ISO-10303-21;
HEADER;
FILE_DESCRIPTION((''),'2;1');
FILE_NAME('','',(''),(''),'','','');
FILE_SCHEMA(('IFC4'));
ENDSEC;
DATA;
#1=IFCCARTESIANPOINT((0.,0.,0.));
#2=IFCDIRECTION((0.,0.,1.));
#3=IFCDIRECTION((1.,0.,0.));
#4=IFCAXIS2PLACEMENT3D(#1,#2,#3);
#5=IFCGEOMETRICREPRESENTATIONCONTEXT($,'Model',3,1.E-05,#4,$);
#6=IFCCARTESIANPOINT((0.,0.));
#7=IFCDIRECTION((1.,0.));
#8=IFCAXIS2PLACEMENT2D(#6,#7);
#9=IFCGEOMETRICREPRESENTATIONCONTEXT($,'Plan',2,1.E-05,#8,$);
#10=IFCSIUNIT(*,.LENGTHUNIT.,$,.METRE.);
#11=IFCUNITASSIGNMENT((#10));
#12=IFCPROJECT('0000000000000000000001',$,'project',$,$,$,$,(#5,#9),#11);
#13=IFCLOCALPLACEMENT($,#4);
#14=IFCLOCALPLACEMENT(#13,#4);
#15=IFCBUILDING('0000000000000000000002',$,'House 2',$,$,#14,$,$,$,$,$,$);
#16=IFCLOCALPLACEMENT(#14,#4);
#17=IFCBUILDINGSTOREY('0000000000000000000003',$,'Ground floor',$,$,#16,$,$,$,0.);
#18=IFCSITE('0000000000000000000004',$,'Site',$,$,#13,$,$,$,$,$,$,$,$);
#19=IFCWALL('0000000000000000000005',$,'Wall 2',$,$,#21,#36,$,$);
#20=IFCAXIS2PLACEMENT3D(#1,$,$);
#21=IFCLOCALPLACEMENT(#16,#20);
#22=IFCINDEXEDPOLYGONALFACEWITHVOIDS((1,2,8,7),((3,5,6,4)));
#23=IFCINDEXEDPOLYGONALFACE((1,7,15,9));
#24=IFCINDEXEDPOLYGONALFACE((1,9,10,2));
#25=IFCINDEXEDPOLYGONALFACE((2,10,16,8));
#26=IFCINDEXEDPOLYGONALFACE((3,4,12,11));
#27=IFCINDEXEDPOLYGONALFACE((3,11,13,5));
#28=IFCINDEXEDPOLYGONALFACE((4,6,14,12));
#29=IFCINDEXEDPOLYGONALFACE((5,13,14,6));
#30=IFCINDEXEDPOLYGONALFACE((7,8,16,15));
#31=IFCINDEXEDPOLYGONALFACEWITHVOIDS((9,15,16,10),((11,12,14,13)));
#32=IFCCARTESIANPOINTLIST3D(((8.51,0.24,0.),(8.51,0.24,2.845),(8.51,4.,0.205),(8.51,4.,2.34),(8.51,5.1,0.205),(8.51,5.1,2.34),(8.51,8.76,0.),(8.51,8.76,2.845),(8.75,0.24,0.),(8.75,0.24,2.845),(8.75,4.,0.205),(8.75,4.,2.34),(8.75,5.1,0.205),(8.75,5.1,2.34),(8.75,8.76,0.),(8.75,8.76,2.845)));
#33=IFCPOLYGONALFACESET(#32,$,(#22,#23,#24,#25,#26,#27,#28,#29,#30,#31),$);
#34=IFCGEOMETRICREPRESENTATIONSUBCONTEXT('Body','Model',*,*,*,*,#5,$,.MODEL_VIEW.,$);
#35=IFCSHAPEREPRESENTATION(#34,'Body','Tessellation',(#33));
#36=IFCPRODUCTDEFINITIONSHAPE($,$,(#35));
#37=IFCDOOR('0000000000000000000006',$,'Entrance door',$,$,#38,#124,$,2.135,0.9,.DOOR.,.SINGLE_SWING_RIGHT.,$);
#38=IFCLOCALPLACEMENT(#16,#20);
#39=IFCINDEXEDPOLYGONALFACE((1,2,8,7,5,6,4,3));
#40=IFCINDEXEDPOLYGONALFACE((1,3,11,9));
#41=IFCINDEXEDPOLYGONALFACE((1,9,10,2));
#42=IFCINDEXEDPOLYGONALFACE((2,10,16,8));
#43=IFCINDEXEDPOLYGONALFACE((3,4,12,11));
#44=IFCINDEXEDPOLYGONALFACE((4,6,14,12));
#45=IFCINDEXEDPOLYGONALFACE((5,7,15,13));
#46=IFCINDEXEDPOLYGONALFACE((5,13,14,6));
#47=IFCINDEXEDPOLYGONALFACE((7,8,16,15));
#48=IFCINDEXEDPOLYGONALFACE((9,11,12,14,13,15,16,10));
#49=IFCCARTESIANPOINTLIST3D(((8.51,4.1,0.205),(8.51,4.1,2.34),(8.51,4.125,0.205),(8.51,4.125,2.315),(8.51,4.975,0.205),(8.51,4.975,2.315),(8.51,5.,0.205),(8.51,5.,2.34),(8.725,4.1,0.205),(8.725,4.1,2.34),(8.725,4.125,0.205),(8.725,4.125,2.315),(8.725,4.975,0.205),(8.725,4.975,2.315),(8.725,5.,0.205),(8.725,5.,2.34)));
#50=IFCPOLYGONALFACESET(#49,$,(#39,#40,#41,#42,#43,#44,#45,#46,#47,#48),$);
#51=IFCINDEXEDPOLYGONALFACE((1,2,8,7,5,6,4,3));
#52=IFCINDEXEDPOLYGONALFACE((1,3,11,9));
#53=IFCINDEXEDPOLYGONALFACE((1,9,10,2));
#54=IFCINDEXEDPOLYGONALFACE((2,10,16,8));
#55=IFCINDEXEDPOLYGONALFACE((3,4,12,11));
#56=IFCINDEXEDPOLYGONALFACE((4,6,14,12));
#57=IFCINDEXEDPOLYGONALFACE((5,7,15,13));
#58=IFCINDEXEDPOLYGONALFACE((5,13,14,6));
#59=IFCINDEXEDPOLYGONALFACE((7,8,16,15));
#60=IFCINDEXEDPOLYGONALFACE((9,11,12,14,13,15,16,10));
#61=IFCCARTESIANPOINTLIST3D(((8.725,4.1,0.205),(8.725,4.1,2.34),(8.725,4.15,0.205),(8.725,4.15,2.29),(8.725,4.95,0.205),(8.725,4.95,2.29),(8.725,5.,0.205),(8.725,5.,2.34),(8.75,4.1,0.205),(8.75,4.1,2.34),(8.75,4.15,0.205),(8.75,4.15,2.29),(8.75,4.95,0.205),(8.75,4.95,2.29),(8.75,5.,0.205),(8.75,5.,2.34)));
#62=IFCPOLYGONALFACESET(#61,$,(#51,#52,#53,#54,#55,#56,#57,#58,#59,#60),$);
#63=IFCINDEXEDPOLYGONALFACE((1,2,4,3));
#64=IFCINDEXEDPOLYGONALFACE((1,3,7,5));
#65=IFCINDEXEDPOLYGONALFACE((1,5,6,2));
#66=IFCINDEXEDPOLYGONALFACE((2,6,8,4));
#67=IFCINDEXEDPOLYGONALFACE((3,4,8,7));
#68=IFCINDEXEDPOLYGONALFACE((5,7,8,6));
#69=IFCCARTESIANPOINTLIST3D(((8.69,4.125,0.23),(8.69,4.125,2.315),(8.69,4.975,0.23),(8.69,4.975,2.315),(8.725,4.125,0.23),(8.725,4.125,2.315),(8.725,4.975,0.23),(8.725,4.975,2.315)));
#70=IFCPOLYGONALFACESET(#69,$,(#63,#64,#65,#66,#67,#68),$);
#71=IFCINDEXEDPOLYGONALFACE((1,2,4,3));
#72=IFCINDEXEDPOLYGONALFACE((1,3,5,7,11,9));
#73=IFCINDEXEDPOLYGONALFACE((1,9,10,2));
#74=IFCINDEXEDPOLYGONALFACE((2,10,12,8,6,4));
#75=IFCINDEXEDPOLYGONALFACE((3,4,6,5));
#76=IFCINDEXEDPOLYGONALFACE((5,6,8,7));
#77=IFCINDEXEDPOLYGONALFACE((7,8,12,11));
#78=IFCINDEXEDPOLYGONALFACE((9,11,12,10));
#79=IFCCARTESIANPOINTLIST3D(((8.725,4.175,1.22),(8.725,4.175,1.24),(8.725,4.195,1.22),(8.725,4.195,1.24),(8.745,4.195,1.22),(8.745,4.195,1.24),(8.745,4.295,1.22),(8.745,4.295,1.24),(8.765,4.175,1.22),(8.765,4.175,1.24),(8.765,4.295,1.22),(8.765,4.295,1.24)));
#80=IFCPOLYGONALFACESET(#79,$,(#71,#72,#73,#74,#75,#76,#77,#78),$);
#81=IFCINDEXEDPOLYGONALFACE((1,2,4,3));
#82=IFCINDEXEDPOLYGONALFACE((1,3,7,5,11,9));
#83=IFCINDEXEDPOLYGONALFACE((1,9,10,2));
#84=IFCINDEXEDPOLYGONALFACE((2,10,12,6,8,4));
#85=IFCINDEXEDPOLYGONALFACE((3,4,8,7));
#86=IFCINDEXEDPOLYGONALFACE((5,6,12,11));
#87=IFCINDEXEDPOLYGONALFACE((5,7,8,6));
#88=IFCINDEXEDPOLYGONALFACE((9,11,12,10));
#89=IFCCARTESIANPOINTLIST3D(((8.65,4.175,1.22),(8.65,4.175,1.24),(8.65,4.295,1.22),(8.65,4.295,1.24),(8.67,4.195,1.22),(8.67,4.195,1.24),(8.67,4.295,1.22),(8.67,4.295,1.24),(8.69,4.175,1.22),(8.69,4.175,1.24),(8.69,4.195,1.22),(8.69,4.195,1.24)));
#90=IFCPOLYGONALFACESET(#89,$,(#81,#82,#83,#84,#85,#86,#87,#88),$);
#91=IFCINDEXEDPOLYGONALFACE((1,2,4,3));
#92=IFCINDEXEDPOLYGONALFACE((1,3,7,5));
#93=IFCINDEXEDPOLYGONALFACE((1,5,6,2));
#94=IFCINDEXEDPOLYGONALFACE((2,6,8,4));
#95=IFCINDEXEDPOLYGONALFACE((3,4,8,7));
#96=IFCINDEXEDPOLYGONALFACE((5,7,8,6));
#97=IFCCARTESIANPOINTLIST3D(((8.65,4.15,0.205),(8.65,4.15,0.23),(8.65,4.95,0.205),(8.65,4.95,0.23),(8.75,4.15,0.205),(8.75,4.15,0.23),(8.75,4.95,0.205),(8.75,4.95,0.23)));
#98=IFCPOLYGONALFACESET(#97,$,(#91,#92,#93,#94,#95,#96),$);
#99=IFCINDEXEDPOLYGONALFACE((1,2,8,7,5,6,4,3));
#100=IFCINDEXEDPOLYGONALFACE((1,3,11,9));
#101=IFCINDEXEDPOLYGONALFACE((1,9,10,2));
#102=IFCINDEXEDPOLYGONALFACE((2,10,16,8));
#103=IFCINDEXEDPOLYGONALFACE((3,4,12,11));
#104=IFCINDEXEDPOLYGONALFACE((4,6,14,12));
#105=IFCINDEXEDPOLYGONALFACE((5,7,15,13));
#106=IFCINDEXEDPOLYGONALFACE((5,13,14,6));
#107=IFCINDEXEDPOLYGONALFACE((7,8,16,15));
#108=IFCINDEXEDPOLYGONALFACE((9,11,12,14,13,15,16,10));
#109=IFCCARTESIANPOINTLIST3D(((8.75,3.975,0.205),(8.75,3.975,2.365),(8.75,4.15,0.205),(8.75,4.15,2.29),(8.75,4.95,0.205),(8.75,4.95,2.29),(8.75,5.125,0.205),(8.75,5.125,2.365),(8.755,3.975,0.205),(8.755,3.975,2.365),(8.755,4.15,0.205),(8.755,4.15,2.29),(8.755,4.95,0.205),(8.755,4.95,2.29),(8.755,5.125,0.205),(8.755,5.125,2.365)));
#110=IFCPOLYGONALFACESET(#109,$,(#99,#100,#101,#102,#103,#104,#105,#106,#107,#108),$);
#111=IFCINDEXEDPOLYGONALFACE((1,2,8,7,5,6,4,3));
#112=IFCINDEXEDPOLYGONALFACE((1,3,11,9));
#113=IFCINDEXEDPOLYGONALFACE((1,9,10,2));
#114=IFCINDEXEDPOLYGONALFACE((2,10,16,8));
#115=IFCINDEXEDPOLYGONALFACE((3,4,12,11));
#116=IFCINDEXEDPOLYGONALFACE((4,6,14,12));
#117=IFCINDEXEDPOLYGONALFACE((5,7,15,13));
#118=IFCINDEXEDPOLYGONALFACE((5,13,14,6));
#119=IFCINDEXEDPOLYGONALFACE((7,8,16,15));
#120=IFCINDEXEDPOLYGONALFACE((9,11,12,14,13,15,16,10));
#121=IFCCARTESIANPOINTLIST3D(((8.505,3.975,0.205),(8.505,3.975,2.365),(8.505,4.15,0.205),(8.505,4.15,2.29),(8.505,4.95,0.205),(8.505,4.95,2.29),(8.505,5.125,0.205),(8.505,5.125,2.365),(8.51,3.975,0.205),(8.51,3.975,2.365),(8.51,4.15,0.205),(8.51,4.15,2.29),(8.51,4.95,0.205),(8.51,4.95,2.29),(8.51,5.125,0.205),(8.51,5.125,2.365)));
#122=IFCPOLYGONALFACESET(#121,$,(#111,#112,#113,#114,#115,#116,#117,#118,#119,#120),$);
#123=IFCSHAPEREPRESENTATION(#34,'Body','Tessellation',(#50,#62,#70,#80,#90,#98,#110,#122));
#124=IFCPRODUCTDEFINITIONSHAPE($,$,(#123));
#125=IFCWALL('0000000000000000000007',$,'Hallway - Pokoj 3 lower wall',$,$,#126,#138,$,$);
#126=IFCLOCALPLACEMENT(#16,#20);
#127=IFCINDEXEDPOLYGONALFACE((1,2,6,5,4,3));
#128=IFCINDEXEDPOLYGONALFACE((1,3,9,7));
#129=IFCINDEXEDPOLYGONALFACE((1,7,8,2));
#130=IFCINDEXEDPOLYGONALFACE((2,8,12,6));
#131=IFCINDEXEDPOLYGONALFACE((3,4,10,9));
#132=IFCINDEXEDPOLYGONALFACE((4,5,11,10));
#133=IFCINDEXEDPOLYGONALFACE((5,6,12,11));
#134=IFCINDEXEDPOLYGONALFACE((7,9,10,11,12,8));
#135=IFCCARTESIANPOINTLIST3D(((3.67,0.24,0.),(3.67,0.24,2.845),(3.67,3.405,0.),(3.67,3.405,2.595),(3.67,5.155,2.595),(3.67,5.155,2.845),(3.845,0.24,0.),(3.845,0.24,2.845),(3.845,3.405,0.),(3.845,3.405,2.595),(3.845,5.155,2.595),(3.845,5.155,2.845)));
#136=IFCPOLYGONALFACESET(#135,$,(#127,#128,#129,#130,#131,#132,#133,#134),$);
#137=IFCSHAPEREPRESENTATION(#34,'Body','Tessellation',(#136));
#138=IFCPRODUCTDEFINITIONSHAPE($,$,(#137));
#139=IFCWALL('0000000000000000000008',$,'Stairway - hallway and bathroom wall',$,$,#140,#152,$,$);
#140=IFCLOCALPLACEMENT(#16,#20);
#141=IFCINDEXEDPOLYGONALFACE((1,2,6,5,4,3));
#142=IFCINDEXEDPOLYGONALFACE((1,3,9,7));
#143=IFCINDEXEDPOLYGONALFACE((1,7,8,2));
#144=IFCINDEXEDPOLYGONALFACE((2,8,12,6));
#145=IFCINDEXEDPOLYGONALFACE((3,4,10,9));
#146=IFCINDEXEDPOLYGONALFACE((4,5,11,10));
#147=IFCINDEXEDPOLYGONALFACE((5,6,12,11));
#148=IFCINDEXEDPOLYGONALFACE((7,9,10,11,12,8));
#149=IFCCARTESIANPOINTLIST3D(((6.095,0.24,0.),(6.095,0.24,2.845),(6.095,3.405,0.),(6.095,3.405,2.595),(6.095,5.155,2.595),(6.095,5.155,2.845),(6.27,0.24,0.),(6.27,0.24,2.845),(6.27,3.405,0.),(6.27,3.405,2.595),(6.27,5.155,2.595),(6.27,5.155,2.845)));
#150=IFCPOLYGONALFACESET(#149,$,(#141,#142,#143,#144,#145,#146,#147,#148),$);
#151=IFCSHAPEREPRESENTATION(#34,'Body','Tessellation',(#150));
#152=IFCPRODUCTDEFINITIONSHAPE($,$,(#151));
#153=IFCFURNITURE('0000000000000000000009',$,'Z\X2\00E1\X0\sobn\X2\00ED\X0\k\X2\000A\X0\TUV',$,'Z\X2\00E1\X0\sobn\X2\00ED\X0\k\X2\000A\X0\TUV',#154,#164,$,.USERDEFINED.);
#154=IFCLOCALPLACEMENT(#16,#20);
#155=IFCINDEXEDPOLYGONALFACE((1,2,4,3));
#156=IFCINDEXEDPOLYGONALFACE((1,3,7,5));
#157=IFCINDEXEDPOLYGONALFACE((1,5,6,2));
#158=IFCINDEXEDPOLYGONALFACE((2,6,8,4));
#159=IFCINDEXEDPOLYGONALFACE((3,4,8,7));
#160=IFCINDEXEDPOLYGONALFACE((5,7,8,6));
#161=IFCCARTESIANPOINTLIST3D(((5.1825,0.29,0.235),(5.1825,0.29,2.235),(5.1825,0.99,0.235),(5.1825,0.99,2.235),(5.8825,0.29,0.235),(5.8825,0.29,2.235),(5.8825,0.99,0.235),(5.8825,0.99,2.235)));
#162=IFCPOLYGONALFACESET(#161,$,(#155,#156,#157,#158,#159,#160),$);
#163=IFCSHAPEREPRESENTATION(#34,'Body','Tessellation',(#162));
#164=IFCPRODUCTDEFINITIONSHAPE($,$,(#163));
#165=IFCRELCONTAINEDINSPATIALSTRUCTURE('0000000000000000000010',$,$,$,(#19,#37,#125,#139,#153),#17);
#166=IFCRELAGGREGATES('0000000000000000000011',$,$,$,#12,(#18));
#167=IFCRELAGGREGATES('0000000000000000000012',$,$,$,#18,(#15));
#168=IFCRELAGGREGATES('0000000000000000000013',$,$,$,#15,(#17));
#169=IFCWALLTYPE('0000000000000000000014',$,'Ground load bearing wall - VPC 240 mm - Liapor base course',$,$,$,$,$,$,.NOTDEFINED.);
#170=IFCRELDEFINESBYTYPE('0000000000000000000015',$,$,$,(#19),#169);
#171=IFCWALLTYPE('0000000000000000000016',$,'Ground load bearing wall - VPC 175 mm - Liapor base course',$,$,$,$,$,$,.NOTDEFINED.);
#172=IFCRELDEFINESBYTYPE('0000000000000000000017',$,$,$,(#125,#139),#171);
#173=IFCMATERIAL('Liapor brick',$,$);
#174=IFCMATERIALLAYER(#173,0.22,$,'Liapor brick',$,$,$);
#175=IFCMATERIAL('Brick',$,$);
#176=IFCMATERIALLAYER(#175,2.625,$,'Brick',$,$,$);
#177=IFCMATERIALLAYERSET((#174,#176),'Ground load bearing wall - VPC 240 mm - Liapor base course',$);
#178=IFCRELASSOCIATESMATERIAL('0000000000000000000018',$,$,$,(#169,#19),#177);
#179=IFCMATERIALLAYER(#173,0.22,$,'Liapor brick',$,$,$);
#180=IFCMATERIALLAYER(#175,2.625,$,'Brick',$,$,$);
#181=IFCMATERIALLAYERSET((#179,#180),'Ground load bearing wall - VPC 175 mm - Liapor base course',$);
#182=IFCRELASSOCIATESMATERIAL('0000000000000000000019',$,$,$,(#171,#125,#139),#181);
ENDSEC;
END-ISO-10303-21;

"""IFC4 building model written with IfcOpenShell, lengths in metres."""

from ifc_helpers import new_model, entity, si_unit, frame, origin_with_axes, origin_2d_with_axis, place, context, subcontext, project, spatial, line, indexed_curve, outline, extrude, shape, source, transform, mapped, material, layer, layer_set, layer_usage, type_object, element, fill, save


model = new_model("IFC4")

# Units and contexts
model_context = context("Model", 3, precision=1e-05, world=origin_with_axes())
plan_context = context("Plan", 2, precision=1e-05, world=origin_2d_with_axis())
body_context_1 = subcontext(model_context, "Body", "Model", "MODEL_VIEW")
body_context_2 = subcontext(plan_context, "Body", "Plan", "PLAN_VIEW")
ifc_project = project(units=[si_unit("LENGTHUNIT", "METRE")], contexts=[model_context, plan_context])

# Site, building, storey
site_placement = place(None, origin_with_axes())
site = spatial("IfcSite", under=ifc_project, at=site_placement, Name="Site")
building_placement = place(site_placement, origin_with_axes())
building = spatial("IfcBuilding", under=site, at=building_placement, Name="House 2")
storey_placement = place(building_placement, origin_with_axes())
storey = spatial("IfcBuildingStorey", under=building, at=storey_placement, Name="Ground floor", Elevation=0.0)

# Shared definitions
ifc_material_1 = material(Name="Liapor brick")
ifc_layer_1 = layer(ifc_material_1, 0.22, Name="Liapor brick")
ifc_material_2 = material(Name="Brick")
ifc_layer_2 = layer(ifc_material_2, 2.625, Name="Brick")
ifc_layer_set_1 = layer_set([ifc_layer_1, ifc_layer_2], Name="Ground load bearing wall - VPC 240 mm - Liapor base course")
wall_type_1 = type_object("IfcWallType", Name="Ground load bearing wall - VPC 240 mm - Liapor base course", PredefinedType="NOTDEFINED", material=ifc_layer_set_1)

# Wall, opening, door
ifc_layer_usage_1 = layer_usage(ifc_layer_set_1, "AXIS3", "POSITIVE", 0.0)
wall_1_placement = place(storey_placement, frame((8.75, 0.24, 0.0), z_axis=(0.0, 0.0, 1.0), x_axis=(0.0, 1.0, 0.0)))
wall_1 = element("IfcWall", 1, at=wall_1_placement, inside=storey, type_object=wall_type_1, material=ifc_layer_usage_1, Name="Wall 2", context=body_context_1, shape_type="SweptSolid", body=[
    extrude(outline(indexed_curve([(0.0, 0.0), (0.0, 0.24), (8.52, 0.24), (8.52, 0.0), (0.0, 0.0)], self_intersect=False)), origin_with_axes(), (0.0, 0.0, 1.0), 2.845),
])
opening_1_placement = place(wall_1_placement, frame((3.76, 0.0, 0.205), z_axis=(0.0, 0.0, 1.0), x_axis=(1.0, 0.0, 0.0)))
opening_1 = element("IfcOpeningElement", 2, at=opening_1_placement, cuts=wall_1, PredefinedType="OPENING", context=body_context_1, shape_type="SweptSolid", body=[
    extrude(outline(indexed_curve([(0.0, 0.0), (0.0, 0.34), (1.1, 0.34), (1.1, 0.0), (0.0, 0.0)], self_intersect=False)), frame((0.0, -0.05, 0.0), z_axis=(0.0, 0.0, 1.0), x_axis=(1.0, 0.0, 0.0)), (0.0, 0.0, 1.0), 2.135),
])
shared_indexed_poly_curve = entity("IfcIndexedPolyCurve", entity("IfcCartesianPointList2D", [[-0.125, 0.0], [-0.125, 2.16], [1.025, 2.16], [1.025, 0.0], [0.85, 0.0], [0.85, 2.085], [0.05, 2.085], [0.05, 0.0]]), [entity("IfcLineIndex", [1, 2, 3, 4, 5, 6, 7, 8, 1])])
shared_shape_1 = source(origin_with_axes(), body_context_2, "Body", "Curve2D", [
    entity("IfcIndexedPolyCurve", entity("IfcCartesianPointList2D", [[0.0, 0.0], [0.0, 0.24], [0.025, 0.24], [0.025, 0.025], [0.05, 0.025], [0.05, 0.0]]), [entity("IfcLineIndex", [1, 2, 3, 4, 5, 6, 1])]),
    entity("IfcIndexedPolyCurve", entity("IfcCartesianPointList2D", [[0.9, 0.0], [0.9, 0.24], [0.875, 0.24], [0.875, 0.025], [0.85, 0.025], [0.85, 0.0]]), [entity("IfcLineIndex", [1, 2, 3, 4, 5, 6, 1])]),
    entity("IfcTrimmedCurve", entity("IfcEllipse", entity("IfcAxis2Placement2D", entity("IfcCartesianPoint", [0.84, 0.24]), entity("IfcDirection", [1.0, 0.0])), 0.815, 0.85), [entity("IfcCartesianPoint", [0.84, 1.09])], [entity("IfcCartesianPoint", [0.025, 0.24])], True, "CARTESIAN"),
    entity("IfcIndexedPolyCurve", entity("IfcCartesianPointList2D", [[0.875, 0.24], [0.84, 0.24], [0.84, 1.09], [0.875, 1.09]]), [entity("IfcLineIndex", [1, 2, 3, 4, 1])]),
])
door_placement = place(opening_1_placement, frame((0.1, 0.0, 0.0), z_axis=(0.0, 0.0, 1.0), x_axis=(1.0, 0.0, 0.0)))
door = element("IfcDoor", 3, at=door_placement, inside=storey, Name="Entrance door", OperationType="SINGLE_SWING_RIGHT", OverallHeight=2.135, OverallWidth=0.9, PredefinedType="DOOR", shapes=[
    shape(body_context_1, "Body", "SweptSolid", [extrude(outline(indexed_curve([(0.0, 0.0), (0.0, 2.135), (0.9, 2.135), (0.9, 0.0), (0.875, 0.0), (0.875, 2.11), (0.025, 2.11), (0.025, 0.0)], segments=[line(1, 2, 3, 4, 5, 6, 7, 8, 1)])), frame((0.0, 0.025, 0.0), z_axis=(0.0, -1.0, 0.0), x_axis=(1.0, 0.0, 0.0)), (0.0, 0.0, -1.0), 0.215), extrude(outline(indexed_curve([(0.0, 0.0), (0.0, 2.135), (0.9, 2.135), (0.9, 0.0), (0.85, 0.0), (0.85, 2.085), (0.05, 2.085), (0.05, 0.0)], segments=[line(1, 2, 3, 4, 5, 6, 7, 8, 1)])), frame((0.0, 0.0, 0.0), z_axis=(0.0, -1.0, 0.0), x_axis=(1.0, 0.0, 0.0)), (0.0, 0.0, -1.0), 0.025), extrude(outline(indexed_curve([(0.0, 0.0), (0.85, 0.0), (0.85, 0.035), (0.0, 0.035)], segments=[line(1, 2, 3, 4, 1)])), frame((0.025, 0.025, 0.025), z_axis=(0.0, 0.0, 1.0), x_axis=(1.0, 0.0, 0.0)), (0.0, 0.0, 1.0), 2.085), extrude(outline(indexed_curve([(0.0, 0.0), (0.0, -0.04), (0.12, -0.04), (0.12, -0.02), (0.02, -0.02), (0.02, 0.0)], segments=[line(1, 2, 3, 4, 5, 6, 1)])), frame((0.075, 0.025, 1.015), z_axis=(0.0, 0.0, 1.0), x_axis=(1.0, 0.0, 0.0)), (0.0, 0.0, 1.0), 0.02), extrude(outline(indexed_curve([(0.0, 0.0), (0.0, 0.04), (0.12, 0.04), (0.12, 0.02), (0.02, 0.02), (0.02, 0.0)], segments=[line(1, 2, 3, 4, 5, 6, 1)])), frame((0.075, 0.06, 1.015), z_axis=(0.0, 0.0, 1.0), x_axis=(1.0, 0.0, 0.0)), (0.0, 0.0, 1.0), 0.02), extrude(outline(indexed_curve([(0.0, 0.0), (0.8, 0.0), (0.8, 0.1), (0.0, 0.1)], segments=[line(1, 2, 3, 4, 1)])), frame((0.05, 0.0, 0.0), z_axis=(0.0, 0.0, 1.0), x_axis=(1.0, 0.0, 0.0)), (0.0, 0.0, 1.0), 0.025), entity("IfcExtrudedAreaSolid", entity("IfcArbitraryClosedProfileDef", "AREA", None, shared_indexed_poly_curve), entity("IfcAxis2Placement3D", entity("IfcCartesianPoint", [0.0, -0.005, 0.0]), entity("IfcDirection", [0.0, -1.0, 0.0]), entity("IfcDirection", [1.0, 0.0, 0.0])), entity("IfcDirection", [0.0, 0.0, -1.0]), 0.005), entity("IfcExtrudedAreaSolid", entity("IfcArbitraryClosedProfileDef", "AREA", None, shared_indexed_poly_curve), entity("IfcAxis2Placement3D", entity("IfcCartesianPoint", [0.0, 0.24, 0.0]), entity("IfcDirection", [0.0, -1.0, 0.0]), entity("IfcDirection", [1.0, 0.0, 0.0])), entity("IfcDirection", [0.0, 0.0, -1.0]), 0.005)]),
    shape(body_context_2, "Body", "MappedRepresentation", [mapped(shared_shape_1, transform((0.0, 0.0, 1.0675), x_axis=(1.0, 0.0, 0.0), y_axis=(0.0, 1.0, 0.0), z_axis=(0.0, 0.0, 1.0), scale=1.0))]),
])
fill(opening_1, door)

# Walls, openings
ifc_layer_3 = layer(ifc_material_1, 0.22, Name="Liapor brick")
ifc_layer_4 = layer(ifc_material_2, 2.625, Name="Brick")
ifc_layer_set_2 = layer_set([ifc_layer_3, ifc_layer_4], Name="Ground load bearing wall - VPC 175 mm - Liapor base course")
ifc_layer_usage_2 = layer_usage(ifc_layer_set_2, "AXIS3", "POSITIVE", 0.0)
wall_type_2 = type_object("IfcWallType", Name="Ground load bearing wall - VPC 175 mm - Liapor base course", PredefinedType="NOTDEFINED", material=ifc_layer_set_2)
wall_2_placement = place(storey_placement, frame((3.845, 0.24, 0.0), z_axis=(0.0, 0.0, 1.0), x_axis=(0.0, 1.0, 0.0)))
wall_2 = element("IfcWall", 4, at=wall_2_placement, inside=storey, type_object=wall_type_2, material=ifc_layer_usage_2, Name="Hallway - Pokoj 3 lower wall", context=body_context_1, shape_type="SweptSolid", body=[
    extrude(outline(indexed_curve([(0.0, 0.0), (0.0, 0.175), (4.915, 0.175), (4.915, 0.0), (0.0, 0.0)], self_intersect=False)), origin_with_axes(), (0.0, 0.0, 1.0), 2.845),
])
opening_2_placement = place(wall_2_placement, frame((3.165, 0.0, 0.0), z_axis=(0.0, 0.0, 1.0), x_axis=(1.0, 0.0, 0.0)))
element("IfcOpeningElement", 5, at=opening_2_placement, cuts=wall_2, PredefinedType="OPENING", context=body_context_1, shape_type="SweptSolid", body=[
    extrude(outline(indexed_curve([(0.0, 0.0), (0.0, 0.275), (1.75, 0.275), (1.75, 0.0), (0.0, 0.0)], self_intersect=False)), frame((0.0, -0.05, 0.0), z_axis=(0.0, 0.0, 1.0), x_axis=(1.0, 0.0, 0.0)), (0.0, 0.0, 1.0), 2.595),
])
ifc_layer_usage_3 = layer_usage(ifc_layer_set_2, "AXIS3", "POSITIVE", 0.0)
wall_3_placement = place(storey_placement, frame((6.27, 0.24, 0.0), z_axis=(0.0, 0.0, 1.0), x_axis=(0.0, 1.0, 0.0)))
wall_3 = element("IfcWall", 6, at=wall_3_placement, inside=storey, type_object=wall_type_2, material=ifc_layer_usage_3, Name="Stairway - hallway and bathroom wall", context=body_context_1, shape_type="SweptSolid", body=[
    extrude(outline(indexed_curve([(0.0, 0.0), (0.0, 0.175), (4.915, 0.175), (4.915, 0.0), (0.0, 0.0)], self_intersect=False)), origin_with_axes(), (0.0, 0.0, 1.0), 2.845),
])
opening_3_placement = place(wall_3_placement, frame((3.165, 0.0, 0.0), z_axis=(0.0, 0.0, 1.0), x_axis=(1.0, 0.0, 0.0)))
element("IfcOpeningElement", 7, at=opening_3_placement, cuts=wall_3, PredefinedType="OPENING", context=body_context_1, shape_type="SweptSolid", body=[
    extrude(outline(indexed_curve([(0.0, 0.0), (0.0, 0.275), (1.75, 0.275), (1.75, 0.0), (0.0, 0.0)], self_intersect=False)), frame((0.0, -0.05, 0.0), z_axis=(0.0, 0.0, 1.0), x_axis=(1.0, 0.0, 0.0)), (0.0, 0.0, 1.0), 2.595),
])

# Furniture
furniture_placement = place(storey_placement, frame((5.5325, 0.64, 0.235), z_axis=(0.0, 0.0, 1.0), x_axis=(1.0, 0.0, 0.0)))
element("IfcFurniture", 8, at=furniture_placement, inside=storey, Name="Zásobník\nTUV", ObjectType="Zásobník\nTUV", PredefinedType="USERDEFINED", shapes=[
    shape(body_context_1, "Body", "SweptSolid", [extrude(outline(indexed_curve([(-0.35, -0.35), (0.35, -0.35), (0.35, 0.35), (-0.35, 0.35)])), None, (0.0, 0.0, 1.0), 2.0)]),
    shape(body_context_2, "Body", "Curve2D", [entity("IfcIndexedPolyCurve", entity("IfcCartesianPointList2D", [[-0.35, -0.35], [0.35, -0.35], [0.35, 0.35], [-0.35, 0.35], [-0.35, -0.35]]), None, False)]),
])

save(model, "model.ifc")
